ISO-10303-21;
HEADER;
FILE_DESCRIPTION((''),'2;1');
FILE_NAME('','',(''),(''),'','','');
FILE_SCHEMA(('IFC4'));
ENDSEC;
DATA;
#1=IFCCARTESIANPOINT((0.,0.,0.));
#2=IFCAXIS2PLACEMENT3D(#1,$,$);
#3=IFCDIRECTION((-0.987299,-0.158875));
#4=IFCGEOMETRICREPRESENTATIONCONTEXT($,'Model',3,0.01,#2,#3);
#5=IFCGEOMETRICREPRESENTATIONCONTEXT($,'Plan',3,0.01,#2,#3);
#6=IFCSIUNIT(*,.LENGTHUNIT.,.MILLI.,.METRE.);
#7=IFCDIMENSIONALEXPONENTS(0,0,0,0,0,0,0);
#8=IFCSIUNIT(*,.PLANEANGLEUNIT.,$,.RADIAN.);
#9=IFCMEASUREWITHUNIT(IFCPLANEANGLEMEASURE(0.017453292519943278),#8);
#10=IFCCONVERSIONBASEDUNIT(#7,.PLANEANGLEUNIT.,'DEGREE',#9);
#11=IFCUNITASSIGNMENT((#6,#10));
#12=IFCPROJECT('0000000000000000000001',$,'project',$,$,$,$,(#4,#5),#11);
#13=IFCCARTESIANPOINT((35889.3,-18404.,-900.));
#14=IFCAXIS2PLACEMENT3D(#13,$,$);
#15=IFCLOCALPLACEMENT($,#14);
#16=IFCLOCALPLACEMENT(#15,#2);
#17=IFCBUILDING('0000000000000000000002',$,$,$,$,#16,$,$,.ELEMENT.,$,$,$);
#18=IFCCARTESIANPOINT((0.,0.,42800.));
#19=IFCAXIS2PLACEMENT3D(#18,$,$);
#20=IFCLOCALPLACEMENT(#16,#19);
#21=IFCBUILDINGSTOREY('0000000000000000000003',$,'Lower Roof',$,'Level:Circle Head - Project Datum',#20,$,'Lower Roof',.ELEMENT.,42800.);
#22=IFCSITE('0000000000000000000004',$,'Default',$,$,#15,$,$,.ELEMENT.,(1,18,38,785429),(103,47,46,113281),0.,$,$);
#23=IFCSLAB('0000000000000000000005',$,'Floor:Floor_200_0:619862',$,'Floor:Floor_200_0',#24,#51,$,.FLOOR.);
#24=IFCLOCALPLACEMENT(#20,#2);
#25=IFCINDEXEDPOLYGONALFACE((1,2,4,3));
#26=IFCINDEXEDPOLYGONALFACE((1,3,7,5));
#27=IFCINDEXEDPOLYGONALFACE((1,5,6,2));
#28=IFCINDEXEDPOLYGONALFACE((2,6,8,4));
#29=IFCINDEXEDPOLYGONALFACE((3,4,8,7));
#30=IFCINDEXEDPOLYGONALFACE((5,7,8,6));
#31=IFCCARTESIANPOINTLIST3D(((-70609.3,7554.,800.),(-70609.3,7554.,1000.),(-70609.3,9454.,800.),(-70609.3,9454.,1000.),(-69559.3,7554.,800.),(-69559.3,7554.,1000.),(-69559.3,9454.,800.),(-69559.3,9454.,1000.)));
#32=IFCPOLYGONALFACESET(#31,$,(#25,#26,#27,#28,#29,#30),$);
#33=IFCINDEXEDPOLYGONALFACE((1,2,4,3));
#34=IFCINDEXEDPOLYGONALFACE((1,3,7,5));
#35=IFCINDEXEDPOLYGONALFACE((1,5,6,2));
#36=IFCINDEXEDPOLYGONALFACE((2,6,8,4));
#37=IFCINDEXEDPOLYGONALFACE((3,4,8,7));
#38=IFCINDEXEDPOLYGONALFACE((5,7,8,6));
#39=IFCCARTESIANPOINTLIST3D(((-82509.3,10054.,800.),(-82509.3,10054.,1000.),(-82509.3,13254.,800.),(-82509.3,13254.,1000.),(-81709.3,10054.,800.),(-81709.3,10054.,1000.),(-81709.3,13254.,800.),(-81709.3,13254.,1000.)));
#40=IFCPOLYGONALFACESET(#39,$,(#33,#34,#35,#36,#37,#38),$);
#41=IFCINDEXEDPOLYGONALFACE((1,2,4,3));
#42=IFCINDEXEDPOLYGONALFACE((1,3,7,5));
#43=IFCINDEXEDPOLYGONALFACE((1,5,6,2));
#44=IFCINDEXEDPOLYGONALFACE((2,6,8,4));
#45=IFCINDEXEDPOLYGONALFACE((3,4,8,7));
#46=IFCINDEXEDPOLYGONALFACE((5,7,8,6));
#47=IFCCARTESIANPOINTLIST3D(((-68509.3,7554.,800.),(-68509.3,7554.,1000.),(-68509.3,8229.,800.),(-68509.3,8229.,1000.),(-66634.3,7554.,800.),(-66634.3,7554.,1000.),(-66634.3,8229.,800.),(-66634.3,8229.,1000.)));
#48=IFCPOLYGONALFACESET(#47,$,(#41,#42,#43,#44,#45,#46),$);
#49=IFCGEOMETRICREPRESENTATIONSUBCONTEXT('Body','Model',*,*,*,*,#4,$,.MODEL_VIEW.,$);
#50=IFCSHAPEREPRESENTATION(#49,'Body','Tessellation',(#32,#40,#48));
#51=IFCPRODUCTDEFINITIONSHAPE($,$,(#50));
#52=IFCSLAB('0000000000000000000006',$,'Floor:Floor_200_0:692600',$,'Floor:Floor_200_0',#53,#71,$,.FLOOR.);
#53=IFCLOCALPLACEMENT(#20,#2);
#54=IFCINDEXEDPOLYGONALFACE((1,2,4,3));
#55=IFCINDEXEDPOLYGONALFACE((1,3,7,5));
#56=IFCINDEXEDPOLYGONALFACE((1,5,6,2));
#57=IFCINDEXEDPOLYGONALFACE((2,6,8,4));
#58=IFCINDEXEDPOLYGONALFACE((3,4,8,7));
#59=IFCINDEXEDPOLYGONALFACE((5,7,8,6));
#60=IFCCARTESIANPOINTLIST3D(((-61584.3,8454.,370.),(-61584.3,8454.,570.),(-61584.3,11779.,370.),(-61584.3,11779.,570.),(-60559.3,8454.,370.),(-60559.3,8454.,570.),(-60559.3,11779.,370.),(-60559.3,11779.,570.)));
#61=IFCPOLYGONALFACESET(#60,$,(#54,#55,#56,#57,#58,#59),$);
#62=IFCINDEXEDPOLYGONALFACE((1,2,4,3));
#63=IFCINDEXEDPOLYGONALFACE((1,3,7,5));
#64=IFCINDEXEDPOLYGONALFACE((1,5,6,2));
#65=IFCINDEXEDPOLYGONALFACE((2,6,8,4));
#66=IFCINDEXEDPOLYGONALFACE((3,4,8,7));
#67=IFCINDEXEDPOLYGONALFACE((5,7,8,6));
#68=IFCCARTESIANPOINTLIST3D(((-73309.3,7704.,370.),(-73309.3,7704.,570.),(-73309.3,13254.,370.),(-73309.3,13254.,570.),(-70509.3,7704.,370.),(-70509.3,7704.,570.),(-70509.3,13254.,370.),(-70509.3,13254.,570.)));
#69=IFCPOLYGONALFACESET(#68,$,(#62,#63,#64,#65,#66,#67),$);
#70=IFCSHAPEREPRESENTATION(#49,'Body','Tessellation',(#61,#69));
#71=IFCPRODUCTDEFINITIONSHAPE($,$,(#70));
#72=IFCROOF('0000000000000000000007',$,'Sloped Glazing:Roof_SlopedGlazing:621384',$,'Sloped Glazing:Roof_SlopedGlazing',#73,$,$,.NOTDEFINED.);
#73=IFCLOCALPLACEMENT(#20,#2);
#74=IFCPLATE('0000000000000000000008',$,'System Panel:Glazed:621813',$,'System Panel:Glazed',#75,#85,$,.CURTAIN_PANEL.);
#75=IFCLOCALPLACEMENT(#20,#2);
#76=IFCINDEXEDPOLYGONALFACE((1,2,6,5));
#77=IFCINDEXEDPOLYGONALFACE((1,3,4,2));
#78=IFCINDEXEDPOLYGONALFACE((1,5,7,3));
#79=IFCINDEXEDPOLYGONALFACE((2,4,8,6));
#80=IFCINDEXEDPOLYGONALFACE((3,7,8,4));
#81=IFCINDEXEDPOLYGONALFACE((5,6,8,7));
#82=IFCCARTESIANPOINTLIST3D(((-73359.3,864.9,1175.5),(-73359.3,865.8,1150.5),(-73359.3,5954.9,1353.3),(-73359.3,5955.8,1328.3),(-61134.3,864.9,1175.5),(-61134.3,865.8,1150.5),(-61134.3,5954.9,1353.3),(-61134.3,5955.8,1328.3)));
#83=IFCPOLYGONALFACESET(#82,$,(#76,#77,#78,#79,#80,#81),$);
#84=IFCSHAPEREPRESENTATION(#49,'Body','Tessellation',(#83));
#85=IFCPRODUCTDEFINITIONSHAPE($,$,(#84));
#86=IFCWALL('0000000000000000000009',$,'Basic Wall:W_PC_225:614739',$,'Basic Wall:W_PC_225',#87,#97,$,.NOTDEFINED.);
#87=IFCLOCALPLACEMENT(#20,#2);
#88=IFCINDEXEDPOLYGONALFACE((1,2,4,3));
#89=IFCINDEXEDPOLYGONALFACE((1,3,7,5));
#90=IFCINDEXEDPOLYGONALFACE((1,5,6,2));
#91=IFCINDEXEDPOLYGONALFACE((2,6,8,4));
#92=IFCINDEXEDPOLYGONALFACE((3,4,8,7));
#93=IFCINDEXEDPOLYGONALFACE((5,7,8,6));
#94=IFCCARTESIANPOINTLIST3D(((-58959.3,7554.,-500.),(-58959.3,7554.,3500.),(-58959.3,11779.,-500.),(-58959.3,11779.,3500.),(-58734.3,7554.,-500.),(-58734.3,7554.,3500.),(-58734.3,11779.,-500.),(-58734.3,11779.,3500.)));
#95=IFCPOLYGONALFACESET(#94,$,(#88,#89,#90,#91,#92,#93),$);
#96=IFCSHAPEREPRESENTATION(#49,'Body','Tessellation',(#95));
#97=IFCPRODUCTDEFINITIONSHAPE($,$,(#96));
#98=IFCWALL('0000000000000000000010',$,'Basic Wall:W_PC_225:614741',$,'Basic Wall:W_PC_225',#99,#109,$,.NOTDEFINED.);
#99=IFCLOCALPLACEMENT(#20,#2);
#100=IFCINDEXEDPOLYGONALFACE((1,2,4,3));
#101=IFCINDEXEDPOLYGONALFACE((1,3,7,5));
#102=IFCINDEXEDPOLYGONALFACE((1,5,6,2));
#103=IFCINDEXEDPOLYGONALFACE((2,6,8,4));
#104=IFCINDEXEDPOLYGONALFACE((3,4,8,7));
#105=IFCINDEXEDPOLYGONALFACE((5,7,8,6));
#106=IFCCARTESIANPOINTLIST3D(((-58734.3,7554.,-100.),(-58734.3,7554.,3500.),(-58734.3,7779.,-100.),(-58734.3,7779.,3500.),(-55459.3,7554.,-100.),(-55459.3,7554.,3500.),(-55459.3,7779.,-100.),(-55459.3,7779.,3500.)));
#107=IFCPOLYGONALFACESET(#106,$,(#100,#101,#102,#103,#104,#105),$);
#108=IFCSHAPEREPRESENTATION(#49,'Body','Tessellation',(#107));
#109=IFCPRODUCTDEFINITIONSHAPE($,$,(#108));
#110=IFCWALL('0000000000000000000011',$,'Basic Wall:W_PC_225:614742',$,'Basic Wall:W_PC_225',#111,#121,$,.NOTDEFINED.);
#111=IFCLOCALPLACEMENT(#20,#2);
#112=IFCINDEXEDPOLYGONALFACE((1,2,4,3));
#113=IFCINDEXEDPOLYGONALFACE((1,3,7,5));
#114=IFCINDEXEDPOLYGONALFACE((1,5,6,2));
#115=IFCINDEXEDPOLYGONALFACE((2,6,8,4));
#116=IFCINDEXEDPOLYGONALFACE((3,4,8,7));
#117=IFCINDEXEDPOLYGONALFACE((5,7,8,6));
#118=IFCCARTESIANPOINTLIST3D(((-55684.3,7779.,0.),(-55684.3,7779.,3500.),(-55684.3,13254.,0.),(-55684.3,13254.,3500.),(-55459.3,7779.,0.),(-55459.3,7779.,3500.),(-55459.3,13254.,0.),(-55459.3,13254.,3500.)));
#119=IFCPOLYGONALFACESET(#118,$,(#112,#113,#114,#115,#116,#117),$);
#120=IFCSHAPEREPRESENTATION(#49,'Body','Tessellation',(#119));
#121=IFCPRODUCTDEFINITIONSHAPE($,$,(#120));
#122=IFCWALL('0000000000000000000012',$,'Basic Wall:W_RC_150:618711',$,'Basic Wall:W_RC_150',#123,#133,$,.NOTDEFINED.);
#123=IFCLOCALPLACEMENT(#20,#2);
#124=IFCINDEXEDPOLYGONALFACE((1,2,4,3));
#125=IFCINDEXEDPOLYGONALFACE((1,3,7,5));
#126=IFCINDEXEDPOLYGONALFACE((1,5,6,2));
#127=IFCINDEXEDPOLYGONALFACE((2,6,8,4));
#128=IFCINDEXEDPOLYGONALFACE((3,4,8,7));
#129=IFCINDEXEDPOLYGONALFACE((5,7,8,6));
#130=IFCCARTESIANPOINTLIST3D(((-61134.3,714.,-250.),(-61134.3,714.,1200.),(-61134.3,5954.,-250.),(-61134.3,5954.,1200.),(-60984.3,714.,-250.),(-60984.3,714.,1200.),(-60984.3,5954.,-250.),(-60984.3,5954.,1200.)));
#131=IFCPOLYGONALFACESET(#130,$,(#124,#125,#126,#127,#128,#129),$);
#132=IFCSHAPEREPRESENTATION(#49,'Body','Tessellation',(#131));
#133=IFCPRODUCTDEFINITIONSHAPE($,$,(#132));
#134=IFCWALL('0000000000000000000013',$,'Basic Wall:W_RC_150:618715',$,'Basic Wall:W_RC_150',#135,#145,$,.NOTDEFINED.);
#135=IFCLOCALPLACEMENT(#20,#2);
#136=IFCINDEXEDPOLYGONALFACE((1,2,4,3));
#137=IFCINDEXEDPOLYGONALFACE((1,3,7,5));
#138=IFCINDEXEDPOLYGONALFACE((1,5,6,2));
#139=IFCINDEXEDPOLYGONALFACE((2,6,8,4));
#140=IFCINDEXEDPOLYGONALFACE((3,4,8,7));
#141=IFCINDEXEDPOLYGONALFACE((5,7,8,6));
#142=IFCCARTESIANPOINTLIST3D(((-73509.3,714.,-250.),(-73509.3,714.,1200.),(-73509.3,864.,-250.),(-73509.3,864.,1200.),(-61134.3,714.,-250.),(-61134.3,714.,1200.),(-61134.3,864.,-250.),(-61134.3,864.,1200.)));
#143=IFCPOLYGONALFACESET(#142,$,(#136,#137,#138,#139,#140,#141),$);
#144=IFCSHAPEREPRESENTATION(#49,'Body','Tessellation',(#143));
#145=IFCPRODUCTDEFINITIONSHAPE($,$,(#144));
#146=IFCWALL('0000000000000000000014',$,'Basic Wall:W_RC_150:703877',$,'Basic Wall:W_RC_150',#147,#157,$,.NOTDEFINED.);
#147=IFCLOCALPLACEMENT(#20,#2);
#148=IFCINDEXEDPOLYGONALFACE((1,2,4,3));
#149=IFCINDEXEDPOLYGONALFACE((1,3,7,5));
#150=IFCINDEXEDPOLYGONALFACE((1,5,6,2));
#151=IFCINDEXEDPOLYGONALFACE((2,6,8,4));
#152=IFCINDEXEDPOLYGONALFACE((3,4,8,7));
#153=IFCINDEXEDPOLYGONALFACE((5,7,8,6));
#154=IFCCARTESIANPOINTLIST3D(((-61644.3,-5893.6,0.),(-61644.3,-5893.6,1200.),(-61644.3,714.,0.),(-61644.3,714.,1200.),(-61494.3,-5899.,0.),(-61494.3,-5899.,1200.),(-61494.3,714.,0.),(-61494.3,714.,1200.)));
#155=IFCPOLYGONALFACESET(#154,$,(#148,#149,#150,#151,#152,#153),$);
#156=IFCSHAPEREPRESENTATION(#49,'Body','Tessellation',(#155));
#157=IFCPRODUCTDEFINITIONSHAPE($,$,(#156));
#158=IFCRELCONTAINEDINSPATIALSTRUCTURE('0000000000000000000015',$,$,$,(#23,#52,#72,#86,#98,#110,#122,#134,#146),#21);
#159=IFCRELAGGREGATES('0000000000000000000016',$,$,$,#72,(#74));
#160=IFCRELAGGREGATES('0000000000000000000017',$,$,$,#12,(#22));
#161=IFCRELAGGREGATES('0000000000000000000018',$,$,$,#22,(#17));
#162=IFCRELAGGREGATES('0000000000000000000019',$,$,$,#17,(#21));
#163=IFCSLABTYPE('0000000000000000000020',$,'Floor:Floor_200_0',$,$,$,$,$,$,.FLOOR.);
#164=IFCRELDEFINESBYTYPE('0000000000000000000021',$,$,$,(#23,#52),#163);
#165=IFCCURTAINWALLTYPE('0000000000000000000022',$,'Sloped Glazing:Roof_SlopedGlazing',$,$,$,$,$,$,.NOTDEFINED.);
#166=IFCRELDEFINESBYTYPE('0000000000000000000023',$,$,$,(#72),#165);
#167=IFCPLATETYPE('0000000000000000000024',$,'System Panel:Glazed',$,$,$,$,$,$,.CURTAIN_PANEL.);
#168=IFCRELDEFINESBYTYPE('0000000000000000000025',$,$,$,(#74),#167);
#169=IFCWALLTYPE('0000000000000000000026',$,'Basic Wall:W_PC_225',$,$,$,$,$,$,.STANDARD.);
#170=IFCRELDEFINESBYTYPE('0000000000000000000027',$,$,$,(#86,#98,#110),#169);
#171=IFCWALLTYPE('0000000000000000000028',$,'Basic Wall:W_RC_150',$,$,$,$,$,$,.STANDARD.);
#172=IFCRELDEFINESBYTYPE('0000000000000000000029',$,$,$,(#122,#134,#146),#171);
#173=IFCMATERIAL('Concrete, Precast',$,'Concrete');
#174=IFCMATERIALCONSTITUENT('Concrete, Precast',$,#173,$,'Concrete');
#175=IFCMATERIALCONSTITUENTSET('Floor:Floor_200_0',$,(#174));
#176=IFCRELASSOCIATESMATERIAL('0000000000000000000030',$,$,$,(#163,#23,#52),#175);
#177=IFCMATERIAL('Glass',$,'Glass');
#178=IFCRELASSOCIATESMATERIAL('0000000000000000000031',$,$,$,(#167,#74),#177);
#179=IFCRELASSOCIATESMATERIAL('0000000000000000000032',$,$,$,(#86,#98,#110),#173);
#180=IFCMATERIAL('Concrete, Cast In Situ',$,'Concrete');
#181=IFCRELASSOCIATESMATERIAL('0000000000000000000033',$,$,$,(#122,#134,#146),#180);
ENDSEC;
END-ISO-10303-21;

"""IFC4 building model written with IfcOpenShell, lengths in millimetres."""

from ifc_helpers import new_model, entity, si_unit, converted_unit, direction, frame, origin, place, context, subcontext, project, spatial, indexed_curve, outline, extrude, source, transform, mapped, material, constituent, constituent_set, type_object, type_shapes, element, aggregate, save


model = new_model("IFC4")

# Units and contexts
model_context = context("Model", 3, precision=0.01, world=origin(), true_north=direction((-0.987299, -0.158875)))
plan_context = context("Plan", 3, precision=0.01, world=origin(), true_north=direction((-0.987299, -0.158875)))
body_context = subcontext(model_context, "Body", "Model", "MODEL_VIEW")
ifc_project = project(units=[si_unit("LENGTHUNIT", "METRE", prefix="MILLI"), converted_unit("PLANEANGLEUNIT", "DEGREE", entity("IfcPlaneAngleMeasure", 0.017453292519943278), si_unit("PLANEANGLEUNIT", "RADIAN"), dimensions=[0, 0, 0, 0, 0, 0, 0])], contexts=[model_context, plan_context])

# Site, building, storey
site_placement = place(None, frame((35889.3, -18404.0, -900.0)))
site = spatial("IfcSite", under=ifc_project, at=site_placement, Name="Default", CompositionType="ELEMENT", RefLatitude=(1, 18, 38, 785429), RefLongitude=(103, 47, 46, 113281), RefElevation=0.0)
building_placement = place(site_placement, origin())
building = spatial("IfcBuilding", under=site, at=building_placement, CompositionType="ELEMENT")
storey_placement = place(building_placement, frame((0.0, 0.0, 42800.0)))
storey = spatial("IfcBuildingStorey", under=building, at=storey_placement, Name="Lower Roof", ObjectType="Level:Circle Head - Project Datum", LongName="Lower Roof", CompositionType="ELEMENT", Elevation=42800.0)

# Shared definitions
ifc_material_1 = material(Name="Concrete, Precast", Category="Concrete")
ifc_constituent_1 = constituent(ifc_material_1, Name="Concrete, Precast", Category="Concrete")
ifc_constituent_set_1 = constituent_set(constituents=[ifc_constituent_1], Name="Floor:Floor_200_0")
slab_type_1 = type_object("IfcSlabType", Name="Floor:Floor_200_0", PredefinedType="FLOOR", material=ifc_constituent_set_1)

# Slabs
slab_1_placement = place(storey_placement, origin())
element("IfcSlab", 1, at=slab_1_placement, inside=storey, type_object=slab_type_1, material=ifc_constituent_set_1, Name="Floor:Floor_200_0:619862", ObjectType="Floor:Floor_200_0", PredefinedType="FLOOR", context=body_context, shape_type="SweptSolid", body=[
    extrude(outline(indexed_curve([(-950.0, -525.0), (950.0, -525.0), (950.0, 525.0), (-950.0, 525.0), (-950.0, -525.0)], self_intersect=False)), frame((-70084.3, 8504.0, 800.0), z_axis=(0.0, 0.0, 1.0), x_axis=(0.0, -1.0, 0.0)), (0.0, 0.0, 1.0), 200.0),
    extrude(outline(indexed_curve([(-1600.0, -400.0), (1600.0, -400.0), (1600.0, 400.0), (-1600.0, 400.0), (-1600.0, -400.0)], self_intersect=False)), frame((-82109.3, 11654.0, 800.0), z_axis=(0.0, 0.0, 1.0), x_axis=(0.0, 1.0, 0.0)), (0.0, 0.0, 1.0), 200.0),
    extrude(outline(indexed_curve([(-937.5, -337.5), (937.5, -337.5), (937.5, 337.5), (-937.5, 337.5), (-937.5, -337.5)], self_intersect=False)), frame((-67571.8, 7891.5, 800.0), z_axis=(0.0, 0.0, 1.0), x_axis=(-1.0, 0.0, 0.0)), (0.0, 0.0, 1.0), 200.0),
])
slab_2_placement = place(storey_placement, origin())
element("IfcSlab", 2, at=slab_2_placement, inside=storey, type_object=slab_type_1, material=ifc_constituent_set_1, Name="Floor:Floor_200_0:692600", ObjectType="Floor:Floor_200_0", PredefinedType="FLOOR", context=body_context, shape_type="SweptSolid", body=[
    extrude(outline(indexed_curve([(-512.5, -1662.5), (512.5, -1662.5), (512.5, 1662.5), (-512.5, 1662.5), (-512.5, -1662.5)], self_intersect=False)), frame((-61071.8, 10116.5, 370.0), z_axis=(0.0, 0.0, 1.0), x_axis=(-1.0, 0.0, 0.0)), (0.0, 0.0, 1.0), 200.0),
    extrude(outline(indexed_curve([(-1400.0, -2775.0), (1400.0, -2775.0), (1400.0, 2775.0), (-1400.0, 2775.0), (-1400.0, -2775.0)], self_intersect=False)), frame((-71909.3, 10479.0, 370.0)), (0.0, 0.0, 1.0), 200.0),
])

# Roof, plate
curtain_wall_type = type_object("IfcCurtainWallType", Name="Sloped Glazing:Roof_SlopedGlazing", PredefinedType="NOTDEFINED")
roof_placement = place(storey_placement, frame((0.0, 0.0, -42800.0)))
roof = element("IfcRoof", 3, at=roof_placement, inside=storey, type_object=curtain_wall_type, Name="Sloped Glazing:Roof_SlopedGlazing:621384", ObjectType="Sloped Glazing:Roof_SlopedGlazing", PredefinedType="NOTDEFINED")
ifc_material_2 = material(Name="Glass", Category="Glass")
plate_type = type_object("IfcPlateType", Name="System Panel:Glazed", PredefinedType="CURTAIN_PANEL", material=ifc_material_2)
shared_shape_1 = source(origin(), body_context, "Body", "SweptSolid", [
    extrude(outline(indexed_curve([(-12.5, -6112.5), (12.5, -6112.5), (12.5, 6112.5), (-12.5, 6112.5), (-12.5, -6112.5)], self_intersect=False)), frame((0.0, 37.0, 0.0), z_axis=(0.0, 0.0, 1.0), x_axis=(0.0, 1.0, 0.0)), (0.0, 0.0, 1.0), 5093.1),
])
type_shapes(plate_type, [shared_shape_1])
plate_placement = place(roof_placement, frame((-67246.8, 864.0, 44000.0), z_axis=(0.0, 0.999391, 0.034899), x_axis=(1.0, 0.0, 0.0)))
plate = element("IfcPlate", 4, at=plate_placement, type_object=plate_type, material=ifc_material_2, Name="System Panel:Glazed:621813", ObjectType="System Panel:Glazed", PredefinedType="CURTAIN_PANEL", context=body_context, shape_type="MappedRepresentation", body=[
    mapped(shared_shape_1, transform((0.0, 0.0, 0.0), scale=1.0)),
])
aggregate(roof, [plate])

# Walls
wall_type_1 = type_object("IfcWallType", Name="Basic Wall:W_PC_225", PredefinedType="STANDARD")
wall_1_placement = place(storey_placement, frame((-58846.8, 7554.0, -500.0), z_axis=(0.0, 0.0, 1.0), x_axis=(0.0, 1.0, 0.0)))
element("IfcWall", 5, at=wall_1_placement, inside=storey, type_object=wall_type_1, material=ifc_material_1, Name="Basic Wall:W_PC_225:614739", ObjectType="Basic Wall:W_PC_225", PredefinedType="NOTDEFINED", context=body_context, shape_type="SweptSolid", body=[
    extrude(outline(indexed_curve([(4225.0, 112.5), (0.0, 112.5), (0.0, -112.5), (4225.0, -112.5), (4225.0, 112.5)], self_intersect=False)), origin(), (0.0, 0.0, 1.0), 4000.0),
])
wall_2_placement = place(storey_placement, frame((-58734.3, 7666.5, -100.0)))
element("IfcWall", 6, at=wall_2_placement, inside=storey, type_object=wall_type_1, material=ifc_material_1, Name="Basic Wall:W_PC_225:614741", ObjectType="Basic Wall:W_PC_225", PredefinedType="NOTDEFINED", context=body_context, shape_type="SweptSolid", body=[
    extrude(outline(indexed_curve([(3275.0, 112.5), (0.0, 112.5), (0.0, -112.5), (3275.0, -112.5), (3275.0, 112.5)], self_intersect=False)), origin(), (0.0, 0.0, 1.0), 3600.0),
])
wall_3_placement = place(storey_placement, frame((-55571.8, 7779.0, 0.0), z_axis=(0.0, 0.0, 1.0), x_axis=(0.0, 1.0, 0.0)))
element("IfcWall", 7, at=wall_3_placement, inside=storey, type_object=wall_type_1, material=ifc_material_1, Name="Basic Wall:W_PC_225:614742", ObjectType="Basic Wall:W_PC_225", PredefinedType="NOTDEFINED", context=body_context, shape_type="SweptSolid", body=[
    extrude(outline(indexed_curve([(5475.0, 112.5), (0.0, 112.5), (0.0, -112.5), (5475.0, -112.5), (5475.0, 112.5)], self_intersect=False)), origin(), (0.0, 0.0, 1.0), 3500.0),
])
ifc_material_3 = material(Name="Concrete, Cast In Situ", Category="Concrete")
wall_type_2 = type_object("IfcWallType", Name="Basic Wall:W_RC_150", PredefinedType="STANDARD")
wall_4_placement = place(storey_placement, frame((-61059.3, 5954.0, -250.0), z_axis=(0.0, 0.0, 1.0), x_axis=(0.0, -1.0, 0.0)))
element("IfcWall", 8, at=wall_4_placement, inside=storey, type_object=wall_type_2, material=ifc_material_3, Name="Basic Wall:W_RC_150:618711", ObjectType="Basic Wall:W_RC_150", PredefinedType="NOTDEFINED", context=body_context, shape_type="SweptSolid", body=[
    extrude(outline(indexed_curve([(5240.0, 75.0), (0.0, 75.0), (0.0, -75.0), (5240.0, -75.0), (5240.0, 75.0)], self_intersect=False)), origin(), (0.0, 0.0, 1.0), 1450.0),
])
wall_5_placement = place(storey_placement, frame((-61134.3, 789.0, -250.0), z_axis=(0.0, 0.0, 1.0), x_axis=(-1.0, 0.0, 0.0)))
element("IfcWall", 9, at=wall_5_placement, inside=storey, type_object=wall_type_2, material=ifc_material_3, Name="Basic Wall:W_RC_150:618715", ObjectType="Basic Wall:W_RC_150", PredefinedType="NOTDEFINED", context=body_context, shape_type="SweptSolid", body=[
    extrude(outline(indexed_curve([(12375.0, 75.0), (0.0, 75.0), (0.0, -75.0), (12375.0, -75.0), (12375.0, 75.0)], self_intersect=False)), origin(), (0.0, 0.0, 1.0), 1450.0),
])
wall_6_placement = place(storey_placement, frame((-61569.3, 714.0, 0.0), z_axis=(0.0, 0.0, 1.0), x_axis=(0.0, -1.0, 0.0)))
element("IfcWall", 10, at=wall_6_placement, inside=storey, type_object=wall_type_2, material=ifc_material_3, Name="Basic Wall:W_RC_150:703877", ObjectType="Basic Wall:W_RC_150", PredefinedType="NOTDEFINED", context=body_context, shape_type="SweptSolid", body=[
    extrude(outline(indexed_curve([(6607.7, -75.0), (6613.0, 75.0), (0.0, 75.0), (0.0, -75.0), (6607.7, -75.0)], self_intersect=False)), origin(), (0.0, 0.0, 1.0), 1200.0),
])

save(model, "model.ifc")
